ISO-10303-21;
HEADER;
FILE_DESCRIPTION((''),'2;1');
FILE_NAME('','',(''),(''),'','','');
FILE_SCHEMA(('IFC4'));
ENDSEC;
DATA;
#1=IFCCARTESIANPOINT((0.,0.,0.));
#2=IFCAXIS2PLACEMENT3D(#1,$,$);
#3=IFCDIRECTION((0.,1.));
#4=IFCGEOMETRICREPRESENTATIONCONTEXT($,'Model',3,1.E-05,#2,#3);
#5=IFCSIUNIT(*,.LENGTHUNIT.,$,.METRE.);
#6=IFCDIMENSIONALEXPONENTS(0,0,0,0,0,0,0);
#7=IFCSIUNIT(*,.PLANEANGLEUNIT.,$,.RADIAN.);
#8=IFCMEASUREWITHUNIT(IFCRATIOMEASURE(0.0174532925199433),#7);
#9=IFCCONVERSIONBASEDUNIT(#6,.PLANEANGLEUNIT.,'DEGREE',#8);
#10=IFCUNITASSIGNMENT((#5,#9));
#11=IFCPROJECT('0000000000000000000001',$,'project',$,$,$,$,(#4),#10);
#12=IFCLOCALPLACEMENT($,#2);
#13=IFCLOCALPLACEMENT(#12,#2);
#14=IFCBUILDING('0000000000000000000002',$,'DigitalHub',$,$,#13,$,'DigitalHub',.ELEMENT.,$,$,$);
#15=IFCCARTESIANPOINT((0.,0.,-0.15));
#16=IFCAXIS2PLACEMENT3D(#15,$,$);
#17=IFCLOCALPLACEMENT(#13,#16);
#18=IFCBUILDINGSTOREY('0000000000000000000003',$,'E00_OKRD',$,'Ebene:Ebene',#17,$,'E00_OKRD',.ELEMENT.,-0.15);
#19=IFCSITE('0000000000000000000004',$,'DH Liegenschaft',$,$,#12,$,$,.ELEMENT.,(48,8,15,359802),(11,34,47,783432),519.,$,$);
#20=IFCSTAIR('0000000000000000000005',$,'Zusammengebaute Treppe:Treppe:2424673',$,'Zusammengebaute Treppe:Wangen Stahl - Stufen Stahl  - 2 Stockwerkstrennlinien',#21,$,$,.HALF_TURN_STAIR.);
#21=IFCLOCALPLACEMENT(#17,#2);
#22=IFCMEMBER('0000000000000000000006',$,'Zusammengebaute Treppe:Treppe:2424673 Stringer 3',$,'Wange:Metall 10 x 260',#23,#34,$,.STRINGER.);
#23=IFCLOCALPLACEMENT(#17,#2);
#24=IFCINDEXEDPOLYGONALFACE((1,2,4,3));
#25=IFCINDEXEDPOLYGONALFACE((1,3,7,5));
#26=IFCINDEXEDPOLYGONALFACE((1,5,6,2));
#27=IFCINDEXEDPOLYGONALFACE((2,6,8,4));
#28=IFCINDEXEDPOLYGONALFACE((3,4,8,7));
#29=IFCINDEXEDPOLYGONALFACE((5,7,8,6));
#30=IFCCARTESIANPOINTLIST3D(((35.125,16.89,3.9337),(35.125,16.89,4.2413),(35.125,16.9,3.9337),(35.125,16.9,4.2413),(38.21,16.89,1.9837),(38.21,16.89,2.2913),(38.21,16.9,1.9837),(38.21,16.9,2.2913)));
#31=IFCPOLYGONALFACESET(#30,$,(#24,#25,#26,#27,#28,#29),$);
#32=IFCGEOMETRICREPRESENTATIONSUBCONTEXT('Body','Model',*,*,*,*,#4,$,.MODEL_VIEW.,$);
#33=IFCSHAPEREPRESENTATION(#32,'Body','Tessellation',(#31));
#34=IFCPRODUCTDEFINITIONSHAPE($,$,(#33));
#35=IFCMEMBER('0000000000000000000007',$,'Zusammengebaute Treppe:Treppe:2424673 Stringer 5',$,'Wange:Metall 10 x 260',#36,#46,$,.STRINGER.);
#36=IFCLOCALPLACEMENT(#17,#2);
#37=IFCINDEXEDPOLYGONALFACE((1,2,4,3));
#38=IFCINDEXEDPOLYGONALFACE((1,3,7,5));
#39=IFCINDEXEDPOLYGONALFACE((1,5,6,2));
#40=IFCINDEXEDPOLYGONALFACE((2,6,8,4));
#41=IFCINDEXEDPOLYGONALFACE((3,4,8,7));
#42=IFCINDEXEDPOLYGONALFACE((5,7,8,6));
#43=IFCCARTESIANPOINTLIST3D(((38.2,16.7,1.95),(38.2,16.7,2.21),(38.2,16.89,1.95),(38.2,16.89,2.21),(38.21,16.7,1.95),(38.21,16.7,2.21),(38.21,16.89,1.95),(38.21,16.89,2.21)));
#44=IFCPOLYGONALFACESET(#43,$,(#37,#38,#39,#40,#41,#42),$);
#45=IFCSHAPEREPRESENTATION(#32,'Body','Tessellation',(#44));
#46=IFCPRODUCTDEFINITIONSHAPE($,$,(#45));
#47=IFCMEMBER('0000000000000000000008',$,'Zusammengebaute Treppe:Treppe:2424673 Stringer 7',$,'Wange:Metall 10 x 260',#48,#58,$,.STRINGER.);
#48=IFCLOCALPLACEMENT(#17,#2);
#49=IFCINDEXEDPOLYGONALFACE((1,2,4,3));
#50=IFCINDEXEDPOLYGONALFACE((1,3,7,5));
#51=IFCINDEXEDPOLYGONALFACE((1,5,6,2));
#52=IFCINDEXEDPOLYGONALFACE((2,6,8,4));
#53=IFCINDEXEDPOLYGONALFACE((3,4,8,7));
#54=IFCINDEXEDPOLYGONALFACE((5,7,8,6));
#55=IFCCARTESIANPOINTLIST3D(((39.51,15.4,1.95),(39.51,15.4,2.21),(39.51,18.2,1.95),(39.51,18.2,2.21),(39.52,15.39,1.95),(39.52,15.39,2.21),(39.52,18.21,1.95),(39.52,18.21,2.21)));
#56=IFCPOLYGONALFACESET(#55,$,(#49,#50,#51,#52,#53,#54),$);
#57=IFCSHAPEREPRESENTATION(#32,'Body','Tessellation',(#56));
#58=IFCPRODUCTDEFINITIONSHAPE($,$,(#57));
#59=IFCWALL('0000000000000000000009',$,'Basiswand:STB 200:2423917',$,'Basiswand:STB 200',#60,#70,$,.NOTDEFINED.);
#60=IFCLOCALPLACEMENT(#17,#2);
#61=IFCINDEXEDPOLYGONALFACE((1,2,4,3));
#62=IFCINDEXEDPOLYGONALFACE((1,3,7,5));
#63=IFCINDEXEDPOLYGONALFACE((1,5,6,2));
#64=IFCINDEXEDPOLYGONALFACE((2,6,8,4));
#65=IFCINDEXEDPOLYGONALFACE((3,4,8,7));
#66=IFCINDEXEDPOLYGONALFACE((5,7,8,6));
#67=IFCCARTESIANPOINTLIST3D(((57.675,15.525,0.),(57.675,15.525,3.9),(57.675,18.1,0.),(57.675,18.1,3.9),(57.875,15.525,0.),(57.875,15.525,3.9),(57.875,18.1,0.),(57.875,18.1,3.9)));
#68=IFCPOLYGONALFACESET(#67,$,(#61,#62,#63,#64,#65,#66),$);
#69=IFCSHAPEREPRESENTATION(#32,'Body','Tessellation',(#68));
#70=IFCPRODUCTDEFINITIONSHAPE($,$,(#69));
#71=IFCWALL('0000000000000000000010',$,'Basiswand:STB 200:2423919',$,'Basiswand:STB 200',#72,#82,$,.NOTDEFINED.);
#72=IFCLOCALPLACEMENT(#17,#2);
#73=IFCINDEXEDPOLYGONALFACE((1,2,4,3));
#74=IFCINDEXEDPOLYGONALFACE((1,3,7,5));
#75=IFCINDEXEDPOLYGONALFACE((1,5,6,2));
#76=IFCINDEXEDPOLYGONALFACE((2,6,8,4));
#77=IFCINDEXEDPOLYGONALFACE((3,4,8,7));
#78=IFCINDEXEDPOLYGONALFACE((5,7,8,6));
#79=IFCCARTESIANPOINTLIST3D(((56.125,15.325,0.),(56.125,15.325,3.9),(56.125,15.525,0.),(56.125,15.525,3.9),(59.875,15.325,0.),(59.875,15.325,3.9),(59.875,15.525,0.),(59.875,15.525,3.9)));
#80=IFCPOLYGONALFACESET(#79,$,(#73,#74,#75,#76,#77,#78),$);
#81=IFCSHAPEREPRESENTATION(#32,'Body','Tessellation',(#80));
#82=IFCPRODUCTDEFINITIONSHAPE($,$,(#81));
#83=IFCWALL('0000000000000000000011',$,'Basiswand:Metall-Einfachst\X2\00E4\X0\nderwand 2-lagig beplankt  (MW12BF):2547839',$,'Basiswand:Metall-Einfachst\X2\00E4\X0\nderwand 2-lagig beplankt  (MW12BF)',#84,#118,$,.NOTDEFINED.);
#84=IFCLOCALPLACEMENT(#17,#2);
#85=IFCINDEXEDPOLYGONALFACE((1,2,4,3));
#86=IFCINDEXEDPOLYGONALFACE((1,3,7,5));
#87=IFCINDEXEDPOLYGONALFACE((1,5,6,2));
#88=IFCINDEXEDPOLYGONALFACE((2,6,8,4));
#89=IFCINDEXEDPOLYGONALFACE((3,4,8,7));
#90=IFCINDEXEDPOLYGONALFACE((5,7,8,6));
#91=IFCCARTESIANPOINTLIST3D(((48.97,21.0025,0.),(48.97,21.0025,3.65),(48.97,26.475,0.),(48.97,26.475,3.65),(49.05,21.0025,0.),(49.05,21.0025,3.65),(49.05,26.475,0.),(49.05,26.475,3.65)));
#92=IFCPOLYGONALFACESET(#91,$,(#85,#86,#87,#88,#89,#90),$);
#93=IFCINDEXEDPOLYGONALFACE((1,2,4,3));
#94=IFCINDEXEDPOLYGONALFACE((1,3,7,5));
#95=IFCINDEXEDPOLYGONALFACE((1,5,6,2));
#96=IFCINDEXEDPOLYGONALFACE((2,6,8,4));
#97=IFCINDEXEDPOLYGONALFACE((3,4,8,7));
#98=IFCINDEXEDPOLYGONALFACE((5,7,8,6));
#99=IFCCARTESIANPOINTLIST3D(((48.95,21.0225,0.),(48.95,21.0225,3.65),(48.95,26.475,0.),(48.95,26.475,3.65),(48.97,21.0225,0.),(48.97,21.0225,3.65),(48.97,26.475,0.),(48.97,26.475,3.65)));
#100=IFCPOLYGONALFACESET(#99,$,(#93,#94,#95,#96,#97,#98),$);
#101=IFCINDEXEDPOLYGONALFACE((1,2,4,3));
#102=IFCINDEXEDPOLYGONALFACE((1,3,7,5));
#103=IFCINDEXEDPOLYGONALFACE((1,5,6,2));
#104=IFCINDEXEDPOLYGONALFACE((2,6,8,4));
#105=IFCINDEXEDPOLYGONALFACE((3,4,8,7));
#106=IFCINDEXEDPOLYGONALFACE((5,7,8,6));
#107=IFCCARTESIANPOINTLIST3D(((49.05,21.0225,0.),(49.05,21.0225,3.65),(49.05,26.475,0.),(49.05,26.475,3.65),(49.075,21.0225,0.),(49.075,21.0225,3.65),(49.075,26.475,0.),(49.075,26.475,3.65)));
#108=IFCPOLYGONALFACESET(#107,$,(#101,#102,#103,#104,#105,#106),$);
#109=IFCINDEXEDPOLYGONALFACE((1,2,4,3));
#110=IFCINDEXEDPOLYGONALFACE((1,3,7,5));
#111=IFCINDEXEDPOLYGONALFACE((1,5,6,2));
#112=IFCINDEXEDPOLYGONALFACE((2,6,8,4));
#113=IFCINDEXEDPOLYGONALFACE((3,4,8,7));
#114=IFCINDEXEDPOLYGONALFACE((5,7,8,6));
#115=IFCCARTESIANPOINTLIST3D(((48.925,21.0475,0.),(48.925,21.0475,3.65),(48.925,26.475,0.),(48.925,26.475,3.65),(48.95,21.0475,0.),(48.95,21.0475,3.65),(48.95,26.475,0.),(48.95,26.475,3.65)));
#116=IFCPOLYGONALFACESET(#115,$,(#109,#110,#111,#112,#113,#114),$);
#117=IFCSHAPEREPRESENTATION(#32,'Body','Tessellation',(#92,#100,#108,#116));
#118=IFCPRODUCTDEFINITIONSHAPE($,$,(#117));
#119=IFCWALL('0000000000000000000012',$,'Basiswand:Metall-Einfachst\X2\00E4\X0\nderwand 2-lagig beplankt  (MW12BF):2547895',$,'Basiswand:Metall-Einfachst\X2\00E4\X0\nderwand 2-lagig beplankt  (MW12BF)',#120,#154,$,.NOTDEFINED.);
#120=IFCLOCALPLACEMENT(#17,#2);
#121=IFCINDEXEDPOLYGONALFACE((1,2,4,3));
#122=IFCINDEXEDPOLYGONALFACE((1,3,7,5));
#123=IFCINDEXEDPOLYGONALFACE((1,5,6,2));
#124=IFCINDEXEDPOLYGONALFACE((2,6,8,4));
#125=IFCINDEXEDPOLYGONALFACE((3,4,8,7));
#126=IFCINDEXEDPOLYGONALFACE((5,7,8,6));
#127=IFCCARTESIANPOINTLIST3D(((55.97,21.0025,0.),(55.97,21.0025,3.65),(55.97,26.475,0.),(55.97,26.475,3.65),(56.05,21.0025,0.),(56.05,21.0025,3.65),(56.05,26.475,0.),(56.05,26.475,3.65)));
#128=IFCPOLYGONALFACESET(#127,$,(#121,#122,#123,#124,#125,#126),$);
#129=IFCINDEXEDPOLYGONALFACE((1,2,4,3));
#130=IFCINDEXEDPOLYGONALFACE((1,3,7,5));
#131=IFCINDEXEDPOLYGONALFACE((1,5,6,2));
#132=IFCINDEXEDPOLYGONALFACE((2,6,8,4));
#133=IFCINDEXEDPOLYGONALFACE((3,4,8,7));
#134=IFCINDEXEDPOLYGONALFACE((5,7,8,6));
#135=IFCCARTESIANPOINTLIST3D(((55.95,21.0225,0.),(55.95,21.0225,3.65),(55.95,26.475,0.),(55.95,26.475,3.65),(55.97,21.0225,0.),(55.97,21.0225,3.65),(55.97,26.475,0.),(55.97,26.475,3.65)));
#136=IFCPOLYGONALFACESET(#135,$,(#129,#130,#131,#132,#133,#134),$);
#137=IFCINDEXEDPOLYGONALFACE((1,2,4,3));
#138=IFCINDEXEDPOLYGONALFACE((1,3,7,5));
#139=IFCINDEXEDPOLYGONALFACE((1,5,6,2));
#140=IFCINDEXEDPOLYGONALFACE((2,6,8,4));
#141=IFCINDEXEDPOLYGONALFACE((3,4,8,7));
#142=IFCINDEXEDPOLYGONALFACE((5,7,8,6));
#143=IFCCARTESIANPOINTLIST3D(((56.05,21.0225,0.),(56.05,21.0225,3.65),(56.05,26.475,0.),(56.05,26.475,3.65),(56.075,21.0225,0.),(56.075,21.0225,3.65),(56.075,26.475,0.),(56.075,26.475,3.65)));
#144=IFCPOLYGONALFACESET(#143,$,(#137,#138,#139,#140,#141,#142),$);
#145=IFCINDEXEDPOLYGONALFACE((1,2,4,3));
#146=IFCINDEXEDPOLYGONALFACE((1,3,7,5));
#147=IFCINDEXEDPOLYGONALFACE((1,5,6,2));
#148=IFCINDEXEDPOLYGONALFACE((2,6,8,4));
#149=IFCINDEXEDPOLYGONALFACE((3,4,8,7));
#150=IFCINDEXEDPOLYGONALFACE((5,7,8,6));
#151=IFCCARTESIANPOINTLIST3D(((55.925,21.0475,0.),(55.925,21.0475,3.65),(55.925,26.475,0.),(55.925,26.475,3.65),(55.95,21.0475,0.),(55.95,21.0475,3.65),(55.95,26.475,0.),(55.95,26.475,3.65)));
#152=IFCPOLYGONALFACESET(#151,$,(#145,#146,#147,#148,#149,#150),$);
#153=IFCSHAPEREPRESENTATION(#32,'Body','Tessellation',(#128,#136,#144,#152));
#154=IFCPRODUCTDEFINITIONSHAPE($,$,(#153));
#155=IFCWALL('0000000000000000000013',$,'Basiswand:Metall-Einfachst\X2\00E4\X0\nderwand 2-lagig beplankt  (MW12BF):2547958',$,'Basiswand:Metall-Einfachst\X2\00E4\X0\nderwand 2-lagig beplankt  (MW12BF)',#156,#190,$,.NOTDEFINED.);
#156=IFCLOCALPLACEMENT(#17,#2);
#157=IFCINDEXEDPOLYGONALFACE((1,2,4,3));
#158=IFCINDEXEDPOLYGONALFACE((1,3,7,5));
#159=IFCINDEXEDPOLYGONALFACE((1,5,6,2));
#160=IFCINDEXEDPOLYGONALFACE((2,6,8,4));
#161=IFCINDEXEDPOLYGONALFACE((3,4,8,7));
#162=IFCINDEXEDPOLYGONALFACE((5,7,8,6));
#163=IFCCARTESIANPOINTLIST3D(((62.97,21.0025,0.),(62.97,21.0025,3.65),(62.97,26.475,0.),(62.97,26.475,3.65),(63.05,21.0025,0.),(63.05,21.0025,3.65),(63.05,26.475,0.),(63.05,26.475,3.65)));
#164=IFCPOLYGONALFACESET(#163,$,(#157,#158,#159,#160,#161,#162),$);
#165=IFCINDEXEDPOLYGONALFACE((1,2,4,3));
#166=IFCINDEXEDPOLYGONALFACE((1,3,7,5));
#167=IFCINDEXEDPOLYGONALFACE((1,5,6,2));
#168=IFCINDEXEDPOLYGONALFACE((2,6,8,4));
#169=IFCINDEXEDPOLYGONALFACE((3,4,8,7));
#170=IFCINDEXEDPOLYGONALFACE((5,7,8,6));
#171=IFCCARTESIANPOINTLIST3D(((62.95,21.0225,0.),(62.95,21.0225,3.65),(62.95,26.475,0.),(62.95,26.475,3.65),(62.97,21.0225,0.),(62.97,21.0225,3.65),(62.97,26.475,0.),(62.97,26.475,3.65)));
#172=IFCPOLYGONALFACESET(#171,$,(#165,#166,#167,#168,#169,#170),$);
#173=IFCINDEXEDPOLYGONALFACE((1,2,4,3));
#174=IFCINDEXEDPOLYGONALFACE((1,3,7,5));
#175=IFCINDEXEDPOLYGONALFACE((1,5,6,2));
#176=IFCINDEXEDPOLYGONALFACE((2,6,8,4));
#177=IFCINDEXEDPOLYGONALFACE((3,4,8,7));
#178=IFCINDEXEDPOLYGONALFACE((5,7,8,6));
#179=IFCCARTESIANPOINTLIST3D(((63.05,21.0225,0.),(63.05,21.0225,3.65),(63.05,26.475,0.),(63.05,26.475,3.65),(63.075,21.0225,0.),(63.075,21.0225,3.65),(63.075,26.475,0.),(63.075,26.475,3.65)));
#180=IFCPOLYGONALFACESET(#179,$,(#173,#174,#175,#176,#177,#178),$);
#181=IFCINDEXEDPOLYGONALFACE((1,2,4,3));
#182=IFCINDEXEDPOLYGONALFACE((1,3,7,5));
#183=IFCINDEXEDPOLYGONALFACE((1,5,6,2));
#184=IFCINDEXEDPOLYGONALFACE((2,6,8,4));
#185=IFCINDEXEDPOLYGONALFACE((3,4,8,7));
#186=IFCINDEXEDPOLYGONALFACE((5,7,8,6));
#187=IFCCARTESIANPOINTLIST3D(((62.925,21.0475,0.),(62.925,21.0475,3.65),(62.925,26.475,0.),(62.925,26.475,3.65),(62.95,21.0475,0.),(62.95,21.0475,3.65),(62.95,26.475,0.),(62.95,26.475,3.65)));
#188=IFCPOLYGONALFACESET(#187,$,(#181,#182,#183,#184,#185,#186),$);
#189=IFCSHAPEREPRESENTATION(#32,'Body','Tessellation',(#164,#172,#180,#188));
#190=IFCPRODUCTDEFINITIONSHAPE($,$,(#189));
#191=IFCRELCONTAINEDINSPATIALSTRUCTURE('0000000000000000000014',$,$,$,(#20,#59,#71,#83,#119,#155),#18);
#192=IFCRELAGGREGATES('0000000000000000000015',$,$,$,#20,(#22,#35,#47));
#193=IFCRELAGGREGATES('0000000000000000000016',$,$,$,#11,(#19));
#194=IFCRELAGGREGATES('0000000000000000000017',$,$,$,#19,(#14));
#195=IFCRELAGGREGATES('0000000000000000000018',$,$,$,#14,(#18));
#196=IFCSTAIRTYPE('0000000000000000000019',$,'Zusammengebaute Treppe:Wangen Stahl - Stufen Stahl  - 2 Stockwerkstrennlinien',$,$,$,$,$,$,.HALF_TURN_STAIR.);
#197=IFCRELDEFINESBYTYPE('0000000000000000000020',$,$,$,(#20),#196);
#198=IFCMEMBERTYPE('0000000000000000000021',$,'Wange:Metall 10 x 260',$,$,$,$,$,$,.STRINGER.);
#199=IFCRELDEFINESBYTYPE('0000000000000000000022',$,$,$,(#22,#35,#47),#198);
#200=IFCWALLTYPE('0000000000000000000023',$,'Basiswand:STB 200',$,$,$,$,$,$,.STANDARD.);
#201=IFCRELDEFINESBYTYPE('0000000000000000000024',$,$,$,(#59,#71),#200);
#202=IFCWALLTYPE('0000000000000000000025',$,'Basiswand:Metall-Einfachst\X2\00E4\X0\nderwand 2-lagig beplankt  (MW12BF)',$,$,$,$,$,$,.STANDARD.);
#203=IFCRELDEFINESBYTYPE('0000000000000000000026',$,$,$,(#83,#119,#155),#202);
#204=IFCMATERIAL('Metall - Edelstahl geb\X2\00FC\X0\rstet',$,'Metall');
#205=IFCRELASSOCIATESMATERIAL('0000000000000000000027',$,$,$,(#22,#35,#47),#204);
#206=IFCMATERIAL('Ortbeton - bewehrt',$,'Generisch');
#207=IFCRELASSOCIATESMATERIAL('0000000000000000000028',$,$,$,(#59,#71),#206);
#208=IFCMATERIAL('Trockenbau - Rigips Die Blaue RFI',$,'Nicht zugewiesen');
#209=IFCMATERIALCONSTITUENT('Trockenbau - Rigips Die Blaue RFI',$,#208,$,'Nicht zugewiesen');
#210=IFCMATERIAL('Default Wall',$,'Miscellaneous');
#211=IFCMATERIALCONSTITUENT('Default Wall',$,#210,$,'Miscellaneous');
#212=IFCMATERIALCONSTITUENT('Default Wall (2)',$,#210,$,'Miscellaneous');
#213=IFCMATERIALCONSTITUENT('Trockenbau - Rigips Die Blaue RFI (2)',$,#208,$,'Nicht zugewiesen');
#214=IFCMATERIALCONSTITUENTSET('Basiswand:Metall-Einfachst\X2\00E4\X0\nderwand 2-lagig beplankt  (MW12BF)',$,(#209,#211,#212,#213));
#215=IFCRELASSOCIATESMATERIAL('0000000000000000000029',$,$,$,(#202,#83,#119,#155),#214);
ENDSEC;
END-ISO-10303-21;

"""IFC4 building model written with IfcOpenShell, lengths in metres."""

from ifc_helpers import new_model, entity, si_unit, converted_unit, direction, frame, origin, place, context, subcontext, project, spatial, indexed_curve, outline, extrude, material, constituent, constituent_set, type_object, element, aggregate, save


model = new_model("IFC4")

# Units and contexts
model_context = context("Model", 3, precision=1e-05, world=origin(), true_north=direction((0.0, 1.0)))
body_context = subcontext(model_context, "Body", "Model", "MODEL_VIEW")
ifc_project = project(units=[si_unit("LENGTHUNIT", "METRE"), converted_unit("PLANEANGLEUNIT", "DEGREE", entity("IfcRatioMeasure", 0.0174532925199433), si_unit("PLANEANGLEUNIT", "RADIAN"), dimensions=[0, 0, 0, 0, 0, 0, 0])], contexts=[model_context])

# Site, building, storey
site_placement = place(None, frame((0.0, 0.0, 0.0)))
site = spatial("IfcSite", under=ifc_project, at=site_placement, Name="DH Liegenschaft", CompositionType="ELEMENT", RefLatitude=(48, 8, 15, 359802), RefLongitude=(11, 34, 47, 783432), RefElevation=519.0)
building_placement = place(site_placement, origin())
building = spatial("IfcBuilding", under=site, at=building_placement, Name="DigitalHub", LongName="DigitalHub", CompositionType="ELEMENT")
storey_placement = place(building_placement, frame((0.0, 0.0, -0.15)))
storey = spatial("IfcBuildingStorey", under=building, at=storey_placement, Name="E00_OKRD", ObjectType="Ebene:Ebene", LongName="E00_OKRD", CompositionType="ELEMENT", Elevation=-0.15)

# Stair, members
stair_type = type_object("IfcStairType", Name="Zusammengebaute Treppe:Wangen Stahl - Stufen Stahl  - 2 Stockwerkstrennlinien", PredefinedType="HALF_TURN_STAIR")
stair_placement = place(storey_placement, origin())
stair = element("IfcStair", 1, at=stair_placement, inside=storey, type_object=stair_type, Name="Zusammengebaute Treppe:Treppe:2424673", ObjectType="Zusammengebaute Treppe:Wangen Stahl - Stufen Stahl  - 2 Stockwerkstrennlinien", PredefinedType="HALF_TURN_STAIR")
ifc_material_1 = material(Name="Metall - Edelstahl gebürstet", Category="Metall")
member_type = type_object("IfcMemberType", Name="Wange:Metall 10 x 260", PredefinedType="STRINGER")
member_1_placement = place(stair_placement, frame((35.125, 16.89, 1.9837)))
member_1 = element("IfcMember", 2, at=member_1_placement, type_object=member_type, material=ifc_material_1, Name="Zusammengebaute Treppe:Treppe:2424673 Stringer 3", ObjectType="Wange:Metall 10 x 260", PredefinedType="STRINGER", context=body_context, shape_type="SweptSolid", body=[
    extrude(outline(indexed_curve([(-1.907, -0.13), (1.7426, -0.13), (1.907, 0.13), (-1.7426, 0.13), (-1.907, -0.13)], self_intersect=False)), frame((1.5425, 0.0, 1.1288), z_axis=(0.0, 1.0, 0.0), x_axis=(-0.845294, 0.0, 0.534302)), (0.0, 0.0, 1.0), 0.01),
])
member_2_placement = place(stair_placement, frame((38.2, 16.7, 1.95)))
member_2 = element("IfcMember", 3, at=member_2_placement, type_object=member_type, material=ifc_material_1, Name="Zusammengebaute Treppe:Treppe:2424673 Stringer 5", ObjectType="Wange:Metall 10 x 260", PredefinedType="STRINGER", context=body_context, shape_type="SweptSolid", body=[
    extrude(outline(indexed_curve([(-0.095, -0.005), (0.095, -0.005), (0.095, 0.005), (-0.095, 0.005), (-0.095, -0.005)], self_intersect=False)), frame((0.005, 0.095, 0.0), z_axis=(0.0, 0.0, 1.0), x_axis=(0.0, -1.0, 0.0)), (0.0, 0.0, 1.0), 0.26),
])
member_3_placement = place(stair_placement, frame((39.51, 15.39, 1.95)))
member_3 = element("IfcMember", 4, at=member_3_placement, type_object=member_type, material=ifc_material_1, Name="Zusammengebaute Treppe:Treppe:2424673 Stringer 7", ObjectType="Wange:Metall 10 x 260", PredefinedType="STRINGER", context=body_context, shape_type="SweptSolid", body=[
    extrude(outline(indexed_curve([(-1.41, -0.005), (1.41, -0.005), (1.4, 0.005), (-1.4, 0.005), (-1.41, -0.005)], self_intersect=False)), frame((0.005, 1.41, 0.0), z_axis=(0.0, 0.0, 1.0), x_axis=(0.0, 1.0, 0.0)), (0.0, 0.0, 1.0), 0.26),
])

# Walls
ifc_material_2 = material(Name="Ortbeton - bewehrt", Category="Generisch")
wall_type_1 = type_object("IfcWallType", Name="Basiswand:STB 200", PredefinedType="STANDARD")
wall_1_placement = place(storey_placement, frame((57.775, 15.525, 0.0), z_axis=(0.0, 0.0, 1.0), x_axis=(0.0, 1.0, 0.0)))
element("IfcWall", 5, at=wall_1_placement, inside=storey, type_object=wall_type_1, material=ifc_material_2, Name="Basiswand:STB 200:2423917", ObjectType="Basiswand:STB 200", PredefinedType="NOTDEFINED", context=body_context, shape_type="SweptSolid", body=[
    extrude(outline(indexed_curve([(2.575, 0.1), (0.0, 0.1), (0.0, -0.1), (2.575, -0.1), (2.575, 0.1)], self_intersect=False)), origin(), (0.0, 0.0, 1.0), 3.9),
])
wall_2_placement = place(storey_placement, frame((59.875, 15.425, 0.0), z_axis=(0.0, 0.0, 1.0), x_axis=(-1.0, 0.0, 0.0)))
element("IfcWall", 6, at=wall_2_placement, inside=storey, type_object=wall_type_1, material=ifc_material_2, Name="Basiswand:STB 200:2423919", ObjectType="Basiswand:STB 200", PredefinedType="NOTDEFINED", context=body_context, shape_type="SweptSolid", body=[
    extrude(outline(indexed_curve([(3.75, 0.1), (0.0, 0.1), (0.0, -0.1), (3.75, -0.1), (3.75, 0.1)], self_intersect=False)), origin(), (0.0, 0.0, 1.0), 3.9),
])
ifc_material_3 = material(Name="Trockenbau - Rigips Die Blaue RFI", Category="Nicht zugewiesen")
ifc_constituent_1 = constituent(ifc_material_3, Name="Trockenbau - Rigips Die Blaue RFI", Category="Nicht zugewiesen")
ifc_material_4 = material(Name="Default Wall", Category="Miscellaneous")
ifc_constituent_2 = constituent(ifc_material_4, Name="Default Wall", Category="Miscellaneous")
ifc_constituent_3 = constituent(ifc_material_4, Name="Default Wall (2)", Category="Miscellaneous")
ifc_constituent_4 = constituent(ifc_material_3, Name="Trockenbau - Rigips Die Blaue RFI (2)", Category="Nicht zugewiesen")
ifc_constituent_set_1 = constituent_set(constituents=[ifc_constituent_1, ifc_constituent_2, ifc_constituent_3, ifc_constituent_4], Name="Basiswand:Metall-Einfachständerwand 2-lagig beplankt  (MW12BF)")
wall_type_2 = type_object("IfcWallType", Name="Basiswand:Metall-Einfachständerwand 2-lagig beplankt  (MW12BF)", PredefinedType="STANDARD", material=ifc_constituent_set_1)
wall_3_placement = place(storey_placement, frame((49.0, 26.475, 0.0), z_axis=(0.0, 0.0, 1.0), x_axis=(0.0, -1.0, 0.0)))
element("IfcWall", 7, at=wall_3_placement, inside=storey, type_object=wall_type_2, material=ifc_constituent_set_1, Name="Basiswand:Metall-Einfachständerwand 2-lagig beplankt  (MW12BF):2547839", ObjectType="Basiswand:Metall-Einfachständerwand 2-lagig beplankt  (MW12BF)", PredefinedType="NOTDEFINED", context=body_context, shape_type="SweptSolid", body=[
    extrude(outline(indexed_curve([(-2.7362, -0.04), (2.7362, -0.04), (2.7362, 0.04), (-2.7362, 0.04), (-2.7362, -0.04)], self_intersect=False)), frame((2.7362, 0.01, 0.0)), (0.0, 0.0, 1.0), 3.65),
    extrude(outline(indexed_curve([(-2.7262, -0.01), (2.7262, -0.01), (2.7262, 0.01), (-2.7262, 0.01), (-2.7262, -0.01)], self_intersect=False)), frame((2.7262, -0.04, 0.0)), (0.0, 0.0, 1.0), 3.65),
    extrude(outline(indexed_curve([(-0.0125, -2.7262), (0.0125, -2.7262), (0.0125, 2.7262), (-0.0125, 2.7262), (-0.0125, -2.7262)], self_intersect=False)), frame((2.7262, 0.0625, 0.0), z_axis=(0.0, 0.0, 1.0), x_axis=(0.0, -1.0, 0.0)), (0.0, 0.0, 1.0), 3.65),
    extrude(outline(indexed_curve([(-0.0125, -2.7137), (0.0125, -2.7137), (0.0125, 2.7137), (-0.0125, 2.7137), (-0.0125, -2.7137)], self_intersect=False)), frame((2.7137, -0.0625, 0.0), z_axis=(0.0, 0.0, 1.0), x_axis=(0.0, 1.0, 0.0)), (0.0, 0.0, 1.0), 3.65),
])
wall_4_placement = place(storey_placement, frame((56.0, 26.475, 0.0), z_axis=(0.0, 0.0, 1.0), x_axis=(0.0, -1.0, 0.0)))
element("IfcWall", 8, at=wall_4_placement, inside=storey, type_object=wall_type_2, material=ifc_constituent_set_1, Name="Basiswand:Metall-Einfachständerwand 2-lagig beplankt  (MW12BF):2547895", ObjectType="Basiswand:Metall-Einfachständerwand 2-lagig beplankt  (MW12BF)", PredefinedType="NOTDEFINED", context=body_context, shape_type="SweptSolid", body=[
    extrude(outline(indexed_curve([(-2.7362, -0.04), (2.7362, -0.04), (2.7362, 0.04), (-2.7362, 0.04), (-2.7362, -0.04)], self_intersect=False)), frame((2.7362, 0.01, 0.0)), (0.0, 0.0, 1.0), 3.65),
    extrude(outline(indexed_curve([(-2.7262, -0.01), (2.7262, -0.01), (2.7262, 0.01), (-2.7262, 0.01), (-2.7262, -0.01)], self_intersect=False)), frame((2.7262, -0.04, 0.0)), (0.0, 0.0, 1.0), 3.65),
    extrude(outline(indexed_curve([(-0.0125, -2.7262), (0.0125, -2.7262), (0.0125, 2.7262), (-0.0125, 2.7262), (-0.0125, -2.7262)], self_intersect=False)), frame((2.7262, 0.0625, 0.0), z_axis=(0.0, 0.0, 1.0), x_axis=(0.0, -1.0, 0.0)), (0.0, 0.0, 1.0), 3.65),
    extrude(outline(indexed_curve([(-0.0125, -2.7137), (0.0125, -2.7137), (0.0125, 2.7137), (-0.0125, 2.7137), (-0.0125, -2.7137)], self_intersect=False)), frame((2.7137, -0.0625, 0.0), z_axis=(0.0, 0.0, 1.0), x_axis=(0.0, 1.0, 0.0)), (0.0, 0.0, 1.0), 3.65),
])
wall_5_placement = place(storey_placement, frame((63.0, 26.475, 0.0), z_axis=(0.0, 0.0, 1.0), x_axis=(0.0, -1.0, 0.0)))
element("IfcWall", 9, at=wall_5_placement, inside=storey, type_object=wall_type_2, material=ifc_constituent_set_1, Name="Basiswand:Metall-Einfachständerwand 2-lagig beplankt  (MW12BF):2547958", ObjectType="Basiswand:Metall-Einfachständerwand 2-lagig beplankt  (MW12BF)", PredefinedType="NOTDEFINED", context=body_context, shape_type="SweptSolid", body=[
    extrude(outline(indexed_curve([(-2.7362, -0.04), (2.7362, -0.04), (2.7362, 0.04), (-2.7362, 0.04), (-2.7362, -0.04)], self_intersect=False)), frame((2.7362, 0.01, 0.0)), (0.0, 0.0, 1.0), 3.65),
    extrude(outline(indexed_curve([(-2.7262, -0.01), (2.7262, -0.01), (2.7262, 0.01), (-2.7262, 0.01), (-2.7262, -0.01)], self_intersect=False)), frame((2.7262, -0.04, 0.0)), (0.0, 0.0, 1.0), 3.65),
    extrude(outline(indexed_curve([(-0.0125, -2.7262), (0.0125, -2.7262), (0.0125, 2.7262), (-0.0125, 2.7262), (-0.0125, -2.7262)], self_intersect=False)), frame((2.7262, 0.0625, 0.0), z_axis=(0.0, 0.0, 1.0), x_axis=(0.0, -1.0, 0.0)), (0.0, 0.0, 1.0), 3.65),
    extrude(outline(indexed_curve([(-0.0125, -2.7137), (0.0125, -2.7137), (0.0125, 2.7137), (-0.0125, 2.7137), (-0.0125, -2.7137)], self_intersect=False)), frame((2.7137, -0.0625, 0.0), z_axis=(0.0, 0.0, 1.0), x_axis=(0.0, 1.0, 0.0)), (0.0, 0.0, 1.0), 3.65),
])

aggregate(stair, [member_1, member_2, member_3])

save(model, "model.ifc")
